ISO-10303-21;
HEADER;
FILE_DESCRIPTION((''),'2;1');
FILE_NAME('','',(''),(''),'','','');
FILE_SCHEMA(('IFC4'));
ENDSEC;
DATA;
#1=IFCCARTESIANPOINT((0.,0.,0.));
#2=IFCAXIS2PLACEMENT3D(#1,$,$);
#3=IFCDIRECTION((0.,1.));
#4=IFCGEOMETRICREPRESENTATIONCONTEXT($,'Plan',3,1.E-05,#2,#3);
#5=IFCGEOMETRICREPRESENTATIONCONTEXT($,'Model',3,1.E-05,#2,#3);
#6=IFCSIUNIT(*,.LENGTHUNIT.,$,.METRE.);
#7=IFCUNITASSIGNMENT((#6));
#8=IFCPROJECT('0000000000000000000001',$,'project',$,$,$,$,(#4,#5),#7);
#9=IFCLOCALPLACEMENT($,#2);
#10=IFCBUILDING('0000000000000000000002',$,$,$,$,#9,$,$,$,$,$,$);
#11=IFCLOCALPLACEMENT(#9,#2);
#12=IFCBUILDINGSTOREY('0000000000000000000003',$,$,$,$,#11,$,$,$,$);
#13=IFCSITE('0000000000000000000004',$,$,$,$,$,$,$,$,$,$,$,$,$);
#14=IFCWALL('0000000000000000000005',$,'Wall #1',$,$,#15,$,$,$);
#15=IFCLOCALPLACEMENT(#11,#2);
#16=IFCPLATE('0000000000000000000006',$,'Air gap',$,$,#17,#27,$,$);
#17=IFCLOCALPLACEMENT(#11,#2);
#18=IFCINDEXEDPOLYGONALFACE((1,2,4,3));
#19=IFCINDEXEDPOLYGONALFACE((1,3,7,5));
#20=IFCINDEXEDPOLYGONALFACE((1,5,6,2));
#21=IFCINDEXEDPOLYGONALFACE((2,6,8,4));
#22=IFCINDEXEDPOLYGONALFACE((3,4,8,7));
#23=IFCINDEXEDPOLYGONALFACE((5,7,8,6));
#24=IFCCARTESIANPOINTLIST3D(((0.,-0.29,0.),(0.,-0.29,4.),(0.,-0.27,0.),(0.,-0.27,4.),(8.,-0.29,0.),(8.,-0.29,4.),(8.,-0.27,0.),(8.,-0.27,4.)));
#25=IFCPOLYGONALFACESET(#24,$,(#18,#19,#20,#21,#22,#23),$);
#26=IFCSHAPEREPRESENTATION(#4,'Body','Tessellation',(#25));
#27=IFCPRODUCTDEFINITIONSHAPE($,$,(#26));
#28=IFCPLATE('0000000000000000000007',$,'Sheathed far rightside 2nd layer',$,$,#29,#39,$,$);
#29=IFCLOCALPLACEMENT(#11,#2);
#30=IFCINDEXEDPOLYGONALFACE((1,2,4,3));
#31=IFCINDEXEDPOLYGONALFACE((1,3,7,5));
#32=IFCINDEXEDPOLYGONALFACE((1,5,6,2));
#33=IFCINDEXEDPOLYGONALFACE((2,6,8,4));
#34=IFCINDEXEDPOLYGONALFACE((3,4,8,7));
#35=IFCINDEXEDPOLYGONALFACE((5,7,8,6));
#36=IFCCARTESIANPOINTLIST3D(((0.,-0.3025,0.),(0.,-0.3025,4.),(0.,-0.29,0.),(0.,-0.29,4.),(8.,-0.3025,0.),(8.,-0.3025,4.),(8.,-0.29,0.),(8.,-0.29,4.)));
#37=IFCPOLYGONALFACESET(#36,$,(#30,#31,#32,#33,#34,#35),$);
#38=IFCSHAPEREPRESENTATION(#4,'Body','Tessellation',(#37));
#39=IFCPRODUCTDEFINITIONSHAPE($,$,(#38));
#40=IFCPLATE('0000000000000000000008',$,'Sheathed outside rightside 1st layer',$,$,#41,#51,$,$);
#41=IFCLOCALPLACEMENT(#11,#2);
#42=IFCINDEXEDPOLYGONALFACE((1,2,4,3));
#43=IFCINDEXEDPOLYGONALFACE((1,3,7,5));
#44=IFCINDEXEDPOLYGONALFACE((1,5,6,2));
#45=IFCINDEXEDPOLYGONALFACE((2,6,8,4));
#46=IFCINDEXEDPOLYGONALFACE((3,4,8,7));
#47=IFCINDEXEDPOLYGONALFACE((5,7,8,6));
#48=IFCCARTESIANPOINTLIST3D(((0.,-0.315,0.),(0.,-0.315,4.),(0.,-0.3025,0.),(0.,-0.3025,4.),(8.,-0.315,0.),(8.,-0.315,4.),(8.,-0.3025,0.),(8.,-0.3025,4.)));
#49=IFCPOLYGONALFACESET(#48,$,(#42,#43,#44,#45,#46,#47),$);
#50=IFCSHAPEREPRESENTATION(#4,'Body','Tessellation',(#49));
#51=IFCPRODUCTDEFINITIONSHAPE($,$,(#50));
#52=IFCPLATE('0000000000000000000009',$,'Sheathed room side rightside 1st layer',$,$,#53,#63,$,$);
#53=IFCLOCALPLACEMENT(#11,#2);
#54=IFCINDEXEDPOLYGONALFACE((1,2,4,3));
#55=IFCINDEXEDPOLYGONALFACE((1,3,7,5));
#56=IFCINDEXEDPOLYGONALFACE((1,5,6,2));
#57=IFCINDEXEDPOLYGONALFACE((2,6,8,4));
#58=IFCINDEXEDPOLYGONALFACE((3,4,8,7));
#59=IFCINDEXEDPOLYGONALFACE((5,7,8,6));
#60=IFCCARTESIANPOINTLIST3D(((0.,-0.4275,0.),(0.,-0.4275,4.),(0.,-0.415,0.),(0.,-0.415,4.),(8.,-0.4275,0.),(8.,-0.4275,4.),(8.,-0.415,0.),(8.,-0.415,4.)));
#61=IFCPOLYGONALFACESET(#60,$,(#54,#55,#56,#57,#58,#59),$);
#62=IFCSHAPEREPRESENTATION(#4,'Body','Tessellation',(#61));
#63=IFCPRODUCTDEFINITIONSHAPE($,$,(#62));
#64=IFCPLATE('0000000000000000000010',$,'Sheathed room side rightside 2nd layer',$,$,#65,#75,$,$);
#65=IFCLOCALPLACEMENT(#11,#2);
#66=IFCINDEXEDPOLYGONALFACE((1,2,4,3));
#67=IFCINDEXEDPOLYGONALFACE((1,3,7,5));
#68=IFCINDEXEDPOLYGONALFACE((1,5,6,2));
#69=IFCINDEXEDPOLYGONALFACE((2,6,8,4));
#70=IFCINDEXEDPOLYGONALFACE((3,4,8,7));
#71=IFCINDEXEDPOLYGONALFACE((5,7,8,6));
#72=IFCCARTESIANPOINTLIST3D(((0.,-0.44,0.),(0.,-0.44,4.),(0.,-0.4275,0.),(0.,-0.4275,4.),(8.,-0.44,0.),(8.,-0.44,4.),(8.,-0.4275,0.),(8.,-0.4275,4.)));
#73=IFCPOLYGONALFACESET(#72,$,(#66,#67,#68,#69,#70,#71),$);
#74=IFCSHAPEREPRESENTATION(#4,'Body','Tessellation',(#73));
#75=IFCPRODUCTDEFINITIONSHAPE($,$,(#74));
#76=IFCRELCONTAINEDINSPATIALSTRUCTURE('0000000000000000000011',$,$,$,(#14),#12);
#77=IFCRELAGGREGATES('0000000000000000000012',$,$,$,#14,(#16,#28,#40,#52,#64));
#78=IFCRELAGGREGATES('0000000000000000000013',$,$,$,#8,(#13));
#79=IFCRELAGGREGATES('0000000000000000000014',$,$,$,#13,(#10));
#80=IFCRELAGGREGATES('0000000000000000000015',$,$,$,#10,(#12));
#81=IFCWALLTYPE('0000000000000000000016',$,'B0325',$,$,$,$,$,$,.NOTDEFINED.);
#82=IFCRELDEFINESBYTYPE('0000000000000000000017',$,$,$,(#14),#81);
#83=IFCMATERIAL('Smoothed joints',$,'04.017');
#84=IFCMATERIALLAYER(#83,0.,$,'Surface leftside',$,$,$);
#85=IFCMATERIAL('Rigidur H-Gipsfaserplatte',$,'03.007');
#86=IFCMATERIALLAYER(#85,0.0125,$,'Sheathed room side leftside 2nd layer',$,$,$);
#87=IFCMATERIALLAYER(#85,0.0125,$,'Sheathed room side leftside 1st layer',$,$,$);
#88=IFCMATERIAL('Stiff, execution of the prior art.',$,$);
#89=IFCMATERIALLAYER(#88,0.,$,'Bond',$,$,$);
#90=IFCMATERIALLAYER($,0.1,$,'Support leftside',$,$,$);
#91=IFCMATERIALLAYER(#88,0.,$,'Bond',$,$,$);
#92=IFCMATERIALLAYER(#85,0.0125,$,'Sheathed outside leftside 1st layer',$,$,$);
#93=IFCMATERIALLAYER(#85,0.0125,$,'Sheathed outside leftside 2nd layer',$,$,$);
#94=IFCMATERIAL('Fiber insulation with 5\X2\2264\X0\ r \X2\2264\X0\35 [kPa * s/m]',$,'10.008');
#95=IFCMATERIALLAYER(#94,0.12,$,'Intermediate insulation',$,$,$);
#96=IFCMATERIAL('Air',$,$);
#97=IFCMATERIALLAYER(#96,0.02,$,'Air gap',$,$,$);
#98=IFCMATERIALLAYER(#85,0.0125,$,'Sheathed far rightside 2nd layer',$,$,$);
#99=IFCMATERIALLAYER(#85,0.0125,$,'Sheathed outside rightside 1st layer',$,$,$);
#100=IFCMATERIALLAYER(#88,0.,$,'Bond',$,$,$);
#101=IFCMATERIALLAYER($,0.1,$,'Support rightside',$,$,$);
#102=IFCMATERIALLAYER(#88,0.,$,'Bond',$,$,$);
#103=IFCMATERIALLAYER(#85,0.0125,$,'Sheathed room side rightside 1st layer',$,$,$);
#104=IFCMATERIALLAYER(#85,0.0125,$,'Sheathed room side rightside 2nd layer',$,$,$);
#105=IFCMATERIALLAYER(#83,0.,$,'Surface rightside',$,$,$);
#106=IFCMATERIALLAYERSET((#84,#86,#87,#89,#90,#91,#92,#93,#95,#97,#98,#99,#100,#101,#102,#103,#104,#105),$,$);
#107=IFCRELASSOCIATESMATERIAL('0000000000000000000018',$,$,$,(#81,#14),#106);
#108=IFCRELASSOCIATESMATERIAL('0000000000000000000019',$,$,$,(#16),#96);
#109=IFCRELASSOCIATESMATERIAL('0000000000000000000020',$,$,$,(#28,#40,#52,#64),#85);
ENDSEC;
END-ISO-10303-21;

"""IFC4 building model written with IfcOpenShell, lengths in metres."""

from ifc_helpers import new_model, si_unit, direction, frame, frame_2d, origin, place, context, project, spatial, rectangle, extrude, material, layer, layer_set, type_object, element, aggregate, save


model = new_model("IFC4")

# Units and contexts
plan_context = context("Plan", 3, precision=1e-05, world=origin(), true_north=direction((0.0, 1.0)))
model_context = context("Model", 3, precision=1e-05, world=origin(), true_north=direction((0.0, 1.0)))
ifc_project = project(units=[si_unit("LENGTHUNIT", "METRE")], contexts=[plan_context, model_context])

# Site, building, storey
site = spatial("IfcSite", under=ifc_project)
building_placement = place(None, origin())
building = spatial("IfcBuilding", under=site, at=building_placement)
storey_placement = place(building_placement, origin())
storey = spatial("IfcBuildingStorey", under=building, at=storey_placement)

# Wall, plates
ifc_material_1 = material(Name="Smoothed joints", Category="04.017")
ifc_layer_1 = layer(ifc_material_1, 0.0, Name="Surface leftside")
ifc_material_2 = material(Name="Rigidur H-Gipsfaserplatte", Category="03.007")
ifc_layer_2 = layer(ifc_material_2, 0.0125, Name="Sheathed room side leftside 2nd layer")
ifc_layer_3 = layer(ifc_material_2, 0.0125, Name="Sheathed room side leftside 1st layer")
ifc_material_3 = material(Name="Stiff, execution of the prior art.")
ifc_layer_4 = layer(ifc_material_3, 0.0, Name="Bond")
ifc_layer_5 = layer(None, 0.1, Name="Support leftside")
ifc_layer_6 = layer(ifc_material_3, 0.0, Name="Bond")
ifc_layer_7 = layer(ifc_material_2, 0.0125, Name="Sheathed outside leftside 1st layer")
ifc_layer_8 = layer(ifc_material_2, 0.0125, Name="Sheathed outside leftside 2nd layer")
ifc_material_4 = material(Name="Fiber insulation with 5≤ r ≤35 [kPa * s/m]", Category="10.008")
ifc_layer_9 = layer(ifc_material_4, 0.12, Name="Intermediate insulation")
ifc_material_5 = material(Name="Air")
ifc_layer_10 = layer(ifc_material_5, 0.02, Name="Air gap")
ifc_layer_11 = layer(ifc_material_2, 0.0125, Name="Sheathed far rightside 2nd layer")
ifc_layer_12 = layer(ifc_material_2, 0.0125, Name="Sheathed outside rightside 1st layer")
ifc_layer_13 = layer(ifc_material_3, 0.0, Name="Bond")
ifc_layer_14 = layer(None, 0.1, Name="Support rightside")
ifc_layer_15 = layer(ifc_material_3, 0.0, Name="Bond")
ifc_layer_16 = layer(ifc_material_2, 0.0125, Name="Sheathed room side rightside 1st layer")
ifc_layer_17 = layer(ifc_material_2, 0.0125, Name="Sheathed room side rightside 2nd layer")
ifc_layer_18 = layer(ifc_material_1, 0.0, Name="Surface rightside")
ifc_layer_set = layer_set([ifc_layer_1, ifc_layer_2, ifc_layer_3, ifc_layer_4, ifc_layer_5, ifc_layer_6, ifc_layer_7, ifc_layer_8, ifc_layer_9, ifc_layer_10, ifc_layer_11, ifc_layer_12, ifc_layer_13, ifc_layer_14, ifc_layer_15, ifc_layer_16, ifc_layer_17, ifc_layer_18])
wall_type = type_object("IfcWallType", Name="B0325", PredefinedType="NOTDEFINED", material=ifc_layer_set)
wall_placement = place(None, frame((0.0, 0.0, 0.0), z_axis=(0.0, -1.0, 0.0), x_axis=(1.0, 0.0, 0.0)))
wall = element("IfcWall", 1, at=wall_placement, inside=storey, type_object=wall_type, material=ifc_layer_set, Name="Wall #1")
plate_1_placement = place(wall_placement, origin())
plate_1 = element("IfcPlate", 2, at=plate_1_placement, material=ifc_material_5, Name="Air gap", context=plan_context, shape_type="SweptSolid", body=[
    extrude(rectangle(XDim=8.0, YDim=4.0, at=frame_2d((4.0, 2.0), x_axis=(1.0, 0.0))), frame((0.0, 0.0, 0.27), z_axis=(0.0, 0.0, 1.0), x_axis=(1.0, 0.0, 0.0)), (0.0, 0.0, 1.0), 0.02),
])
plate_2_placement = place(wall_placement, origin())
plate_2 = element("IfcPlate", 3, at=plate_2_placement, material=ifc_material_2, Name="Sheathed far rightside 2nd layer", context=plan_context, shape_type="SweptSolid", body=[
    extrude(rectangle(XDim=8.0, YDim=4.0, at=frame_2d((4.0, 2.0), x_axis=(1.0, 0.0))), frame((0.0, 0.0, 0.29), z_axis=(0.0, 0.0, 1.0), x_axis=(1.0, 0.0, 0.0)), (0.0, 0.0, 1.0), 0.0125),
])
plate_3_placement = place(wall_placement, origin())
plate_3 = element("IfcPlate", 4, at=plate_3_placement, material=ifc_material_2, Name="Sheathed outside rightside 1st layer", context=plan_context, shape_type="SweptSolid", body=[
    extrude(rectangle(XDim=8.0, YDim=4.0, at=frame_2d((4.0, 2.0), x_axis=(1.0, 0.0))), frame((0.0, 0.0, 0.3025), z_axis=(0.0, 0.0, 1.0), x_axis=(1.0, 0.0, 0.0)), (0.0, 0.0, 1.0), 0.0125),
])
plate_4_placement = place(wall_placement, origin())
plate_4 = element("IfcPlate", 5, at=plate_4_placement, material=ifc_material_2, Name="Sheathed room side rightside 1st layer", context=plan_context, shape_type="SweptSolid", body=[
    extrude(rectangle(XDim=8.0, YDim=4.0, at=frame_2d((4.0, 2.0), x_axis=(1.0, 0.0))), frame((0.0, 0.0, 0.415), z_axis=(0.0, 0.0, 1.0), x_axis=(1.0, 0.0, 0.0)), (0.0, 0.0, 1.0), 0.0125),
])
plate_5_placement = place(wall_placement, origin())
plate_5 = element("IfcPlate", 6, at=plate_5_placement, material=ifc_material_2, Name="Sheathed room side rightside 2nd layer", context=plan_context, shape_type="SweptSolid", body=[
    extrude(rectangle(XDim=8.0, YDim=4.0, at=frame_2d((4.0, 2.0), x_axis=(1.0, 0.0))), frame((0.0, 0.0, 0.4275), z_axis=(0.0, 0.0, 1.0), x_axis=(1.0, 0.0, 0.0)), (0.0, 0.0, 1.0), 0.0125),
])
aggregate(wall, [plate_1, plate_2, plate_3, plate_4, plate_5])

save(model, "model.ifc")
